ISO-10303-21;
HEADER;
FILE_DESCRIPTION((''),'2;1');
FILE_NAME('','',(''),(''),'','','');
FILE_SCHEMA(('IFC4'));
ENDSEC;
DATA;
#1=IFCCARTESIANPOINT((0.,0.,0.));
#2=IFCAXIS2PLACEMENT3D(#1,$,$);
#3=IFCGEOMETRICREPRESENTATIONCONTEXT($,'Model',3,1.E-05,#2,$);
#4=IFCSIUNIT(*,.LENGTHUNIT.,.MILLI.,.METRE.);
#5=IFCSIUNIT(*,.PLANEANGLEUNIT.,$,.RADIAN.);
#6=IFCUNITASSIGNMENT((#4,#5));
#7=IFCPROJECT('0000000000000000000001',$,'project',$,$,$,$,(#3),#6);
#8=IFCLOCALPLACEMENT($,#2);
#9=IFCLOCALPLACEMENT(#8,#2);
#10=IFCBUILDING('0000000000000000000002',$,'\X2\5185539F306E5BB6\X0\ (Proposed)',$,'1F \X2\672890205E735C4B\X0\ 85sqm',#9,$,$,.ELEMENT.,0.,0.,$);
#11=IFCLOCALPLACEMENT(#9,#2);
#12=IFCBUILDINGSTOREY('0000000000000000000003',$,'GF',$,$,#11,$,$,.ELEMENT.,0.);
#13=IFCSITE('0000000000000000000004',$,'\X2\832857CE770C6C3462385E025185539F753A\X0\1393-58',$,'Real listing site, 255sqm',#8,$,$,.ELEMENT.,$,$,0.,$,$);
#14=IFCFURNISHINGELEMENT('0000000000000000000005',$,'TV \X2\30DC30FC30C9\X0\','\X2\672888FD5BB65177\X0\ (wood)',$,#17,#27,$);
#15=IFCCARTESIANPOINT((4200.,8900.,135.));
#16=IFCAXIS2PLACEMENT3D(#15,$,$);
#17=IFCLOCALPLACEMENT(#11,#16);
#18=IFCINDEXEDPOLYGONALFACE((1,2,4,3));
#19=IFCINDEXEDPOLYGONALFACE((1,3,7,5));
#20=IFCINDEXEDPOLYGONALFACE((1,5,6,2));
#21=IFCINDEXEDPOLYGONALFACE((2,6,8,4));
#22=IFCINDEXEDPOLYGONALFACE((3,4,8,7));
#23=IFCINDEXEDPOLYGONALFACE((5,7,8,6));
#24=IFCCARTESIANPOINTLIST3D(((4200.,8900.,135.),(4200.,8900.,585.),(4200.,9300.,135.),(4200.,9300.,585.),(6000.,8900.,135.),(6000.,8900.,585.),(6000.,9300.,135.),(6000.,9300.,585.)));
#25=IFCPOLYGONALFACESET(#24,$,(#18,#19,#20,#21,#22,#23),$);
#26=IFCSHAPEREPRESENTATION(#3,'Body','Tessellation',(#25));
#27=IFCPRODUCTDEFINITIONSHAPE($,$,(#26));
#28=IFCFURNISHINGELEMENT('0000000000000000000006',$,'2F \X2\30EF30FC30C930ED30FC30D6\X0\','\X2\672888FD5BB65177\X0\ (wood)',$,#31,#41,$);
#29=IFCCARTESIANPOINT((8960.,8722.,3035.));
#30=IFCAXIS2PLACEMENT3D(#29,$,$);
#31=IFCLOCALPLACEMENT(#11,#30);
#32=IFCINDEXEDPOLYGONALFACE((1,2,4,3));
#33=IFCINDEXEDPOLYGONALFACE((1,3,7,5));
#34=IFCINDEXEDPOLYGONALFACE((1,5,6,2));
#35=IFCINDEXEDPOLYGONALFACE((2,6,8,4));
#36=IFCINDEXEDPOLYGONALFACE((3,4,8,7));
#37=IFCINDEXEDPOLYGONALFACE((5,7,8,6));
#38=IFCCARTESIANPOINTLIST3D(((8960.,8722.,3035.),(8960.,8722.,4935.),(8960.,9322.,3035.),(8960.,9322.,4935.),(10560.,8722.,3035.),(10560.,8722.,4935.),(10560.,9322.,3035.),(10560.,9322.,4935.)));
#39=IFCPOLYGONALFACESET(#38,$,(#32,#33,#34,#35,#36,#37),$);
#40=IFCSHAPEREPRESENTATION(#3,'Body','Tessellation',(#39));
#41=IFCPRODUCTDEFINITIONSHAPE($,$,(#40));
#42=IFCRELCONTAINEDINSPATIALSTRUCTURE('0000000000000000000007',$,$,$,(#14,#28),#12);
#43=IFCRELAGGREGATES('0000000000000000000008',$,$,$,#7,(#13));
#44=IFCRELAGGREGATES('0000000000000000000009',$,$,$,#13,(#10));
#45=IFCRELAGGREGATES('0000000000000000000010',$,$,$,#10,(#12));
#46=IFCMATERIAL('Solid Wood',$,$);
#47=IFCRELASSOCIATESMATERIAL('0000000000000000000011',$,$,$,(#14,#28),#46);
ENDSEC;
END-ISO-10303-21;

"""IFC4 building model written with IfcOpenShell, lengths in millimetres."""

from ifc_helpers import new_model, si_unit, frame, frame_2d, origin, place, context, project, spatial, rectangle, extrude, material, element, save


model = new_model("IFC4")

# Units and contexts
model_context = context("Model", 3, precision=1e-05, world=origin())
ifc_project = project(units=[si_unit("LENGTHUNIT", "METRE", prefix="MILLI"), si_unit("PLANEANGLEUNIT", "RADIAN")], contexts=[model_context])

# Site, building, storey
site_placement = place(None, origin())
site = spatial("IfcSite", under=ifc_project, at=site_placement, Name="茨城県水戸市内原町1393-58", ObjectType="Real listing site, 255sqm", CompositionType="ELEMENT", RefElevation=0.0)
building_placement = place(site_placement, origin())
building = spatial("IfcBuilding", under=site, at=building_placement, Name="内原の家 (Proposed)", ObjectType="1F 木造平屋 85sqm", CompositionType="ELEMENT", ElevationOfRefHeight=0.0, ElevationOfTerrain=0.0)
storey_placement = place(building_placement, origin())
storey = spatial("IfcBuildingStorey", under=building, at=storey_placement, Name="GF", CompositionType="ELEMENT", Elevation=0.0)

# Shared definitions
ifc_material_1 = material(Name="Solid Wood")

# Furnishing elements
furnishing_1_placement = place(storey_placement, frame((4200.0, 8900.0, 135.0)))
element("IfcFurnishingElement", 1, at=furnishing_1_placement, inside=storey, material=ifc_material_1, Name="TV ボード", Description="木製家具 (wood)", context=model_context, shape_type="SweptSolid", body=[
    extrude(rectangle(XDim=1800.0, YDim=400.0, at=frame_2d((900.0, 200.0))), frame((4200.0, 8900.0, 135.0)), (0.0, 0.0, 1.0), 450.0),
])
furnishing_2_placement = place(storey_placement, frame((8960.0, 8722.0, 3035.0)))
element("IfcFurnishingElement", 2, at=furnishing_2_placement, inside=storey, material=ifc_material_1, Name="2F ワードローブ", Description="木製家具 (wood)", context=model_context, shape_type="SweptSolid", body=[
    extrude(rectangle(XDim=1600.0, YDim=600.0, at=frame_2d((800.0, 300.0))), frame((8960.0, 8722.0, 3035.0)), (0.0, 0.0, 1.0), 1900.0),
])

save(model, "model.ifc")
